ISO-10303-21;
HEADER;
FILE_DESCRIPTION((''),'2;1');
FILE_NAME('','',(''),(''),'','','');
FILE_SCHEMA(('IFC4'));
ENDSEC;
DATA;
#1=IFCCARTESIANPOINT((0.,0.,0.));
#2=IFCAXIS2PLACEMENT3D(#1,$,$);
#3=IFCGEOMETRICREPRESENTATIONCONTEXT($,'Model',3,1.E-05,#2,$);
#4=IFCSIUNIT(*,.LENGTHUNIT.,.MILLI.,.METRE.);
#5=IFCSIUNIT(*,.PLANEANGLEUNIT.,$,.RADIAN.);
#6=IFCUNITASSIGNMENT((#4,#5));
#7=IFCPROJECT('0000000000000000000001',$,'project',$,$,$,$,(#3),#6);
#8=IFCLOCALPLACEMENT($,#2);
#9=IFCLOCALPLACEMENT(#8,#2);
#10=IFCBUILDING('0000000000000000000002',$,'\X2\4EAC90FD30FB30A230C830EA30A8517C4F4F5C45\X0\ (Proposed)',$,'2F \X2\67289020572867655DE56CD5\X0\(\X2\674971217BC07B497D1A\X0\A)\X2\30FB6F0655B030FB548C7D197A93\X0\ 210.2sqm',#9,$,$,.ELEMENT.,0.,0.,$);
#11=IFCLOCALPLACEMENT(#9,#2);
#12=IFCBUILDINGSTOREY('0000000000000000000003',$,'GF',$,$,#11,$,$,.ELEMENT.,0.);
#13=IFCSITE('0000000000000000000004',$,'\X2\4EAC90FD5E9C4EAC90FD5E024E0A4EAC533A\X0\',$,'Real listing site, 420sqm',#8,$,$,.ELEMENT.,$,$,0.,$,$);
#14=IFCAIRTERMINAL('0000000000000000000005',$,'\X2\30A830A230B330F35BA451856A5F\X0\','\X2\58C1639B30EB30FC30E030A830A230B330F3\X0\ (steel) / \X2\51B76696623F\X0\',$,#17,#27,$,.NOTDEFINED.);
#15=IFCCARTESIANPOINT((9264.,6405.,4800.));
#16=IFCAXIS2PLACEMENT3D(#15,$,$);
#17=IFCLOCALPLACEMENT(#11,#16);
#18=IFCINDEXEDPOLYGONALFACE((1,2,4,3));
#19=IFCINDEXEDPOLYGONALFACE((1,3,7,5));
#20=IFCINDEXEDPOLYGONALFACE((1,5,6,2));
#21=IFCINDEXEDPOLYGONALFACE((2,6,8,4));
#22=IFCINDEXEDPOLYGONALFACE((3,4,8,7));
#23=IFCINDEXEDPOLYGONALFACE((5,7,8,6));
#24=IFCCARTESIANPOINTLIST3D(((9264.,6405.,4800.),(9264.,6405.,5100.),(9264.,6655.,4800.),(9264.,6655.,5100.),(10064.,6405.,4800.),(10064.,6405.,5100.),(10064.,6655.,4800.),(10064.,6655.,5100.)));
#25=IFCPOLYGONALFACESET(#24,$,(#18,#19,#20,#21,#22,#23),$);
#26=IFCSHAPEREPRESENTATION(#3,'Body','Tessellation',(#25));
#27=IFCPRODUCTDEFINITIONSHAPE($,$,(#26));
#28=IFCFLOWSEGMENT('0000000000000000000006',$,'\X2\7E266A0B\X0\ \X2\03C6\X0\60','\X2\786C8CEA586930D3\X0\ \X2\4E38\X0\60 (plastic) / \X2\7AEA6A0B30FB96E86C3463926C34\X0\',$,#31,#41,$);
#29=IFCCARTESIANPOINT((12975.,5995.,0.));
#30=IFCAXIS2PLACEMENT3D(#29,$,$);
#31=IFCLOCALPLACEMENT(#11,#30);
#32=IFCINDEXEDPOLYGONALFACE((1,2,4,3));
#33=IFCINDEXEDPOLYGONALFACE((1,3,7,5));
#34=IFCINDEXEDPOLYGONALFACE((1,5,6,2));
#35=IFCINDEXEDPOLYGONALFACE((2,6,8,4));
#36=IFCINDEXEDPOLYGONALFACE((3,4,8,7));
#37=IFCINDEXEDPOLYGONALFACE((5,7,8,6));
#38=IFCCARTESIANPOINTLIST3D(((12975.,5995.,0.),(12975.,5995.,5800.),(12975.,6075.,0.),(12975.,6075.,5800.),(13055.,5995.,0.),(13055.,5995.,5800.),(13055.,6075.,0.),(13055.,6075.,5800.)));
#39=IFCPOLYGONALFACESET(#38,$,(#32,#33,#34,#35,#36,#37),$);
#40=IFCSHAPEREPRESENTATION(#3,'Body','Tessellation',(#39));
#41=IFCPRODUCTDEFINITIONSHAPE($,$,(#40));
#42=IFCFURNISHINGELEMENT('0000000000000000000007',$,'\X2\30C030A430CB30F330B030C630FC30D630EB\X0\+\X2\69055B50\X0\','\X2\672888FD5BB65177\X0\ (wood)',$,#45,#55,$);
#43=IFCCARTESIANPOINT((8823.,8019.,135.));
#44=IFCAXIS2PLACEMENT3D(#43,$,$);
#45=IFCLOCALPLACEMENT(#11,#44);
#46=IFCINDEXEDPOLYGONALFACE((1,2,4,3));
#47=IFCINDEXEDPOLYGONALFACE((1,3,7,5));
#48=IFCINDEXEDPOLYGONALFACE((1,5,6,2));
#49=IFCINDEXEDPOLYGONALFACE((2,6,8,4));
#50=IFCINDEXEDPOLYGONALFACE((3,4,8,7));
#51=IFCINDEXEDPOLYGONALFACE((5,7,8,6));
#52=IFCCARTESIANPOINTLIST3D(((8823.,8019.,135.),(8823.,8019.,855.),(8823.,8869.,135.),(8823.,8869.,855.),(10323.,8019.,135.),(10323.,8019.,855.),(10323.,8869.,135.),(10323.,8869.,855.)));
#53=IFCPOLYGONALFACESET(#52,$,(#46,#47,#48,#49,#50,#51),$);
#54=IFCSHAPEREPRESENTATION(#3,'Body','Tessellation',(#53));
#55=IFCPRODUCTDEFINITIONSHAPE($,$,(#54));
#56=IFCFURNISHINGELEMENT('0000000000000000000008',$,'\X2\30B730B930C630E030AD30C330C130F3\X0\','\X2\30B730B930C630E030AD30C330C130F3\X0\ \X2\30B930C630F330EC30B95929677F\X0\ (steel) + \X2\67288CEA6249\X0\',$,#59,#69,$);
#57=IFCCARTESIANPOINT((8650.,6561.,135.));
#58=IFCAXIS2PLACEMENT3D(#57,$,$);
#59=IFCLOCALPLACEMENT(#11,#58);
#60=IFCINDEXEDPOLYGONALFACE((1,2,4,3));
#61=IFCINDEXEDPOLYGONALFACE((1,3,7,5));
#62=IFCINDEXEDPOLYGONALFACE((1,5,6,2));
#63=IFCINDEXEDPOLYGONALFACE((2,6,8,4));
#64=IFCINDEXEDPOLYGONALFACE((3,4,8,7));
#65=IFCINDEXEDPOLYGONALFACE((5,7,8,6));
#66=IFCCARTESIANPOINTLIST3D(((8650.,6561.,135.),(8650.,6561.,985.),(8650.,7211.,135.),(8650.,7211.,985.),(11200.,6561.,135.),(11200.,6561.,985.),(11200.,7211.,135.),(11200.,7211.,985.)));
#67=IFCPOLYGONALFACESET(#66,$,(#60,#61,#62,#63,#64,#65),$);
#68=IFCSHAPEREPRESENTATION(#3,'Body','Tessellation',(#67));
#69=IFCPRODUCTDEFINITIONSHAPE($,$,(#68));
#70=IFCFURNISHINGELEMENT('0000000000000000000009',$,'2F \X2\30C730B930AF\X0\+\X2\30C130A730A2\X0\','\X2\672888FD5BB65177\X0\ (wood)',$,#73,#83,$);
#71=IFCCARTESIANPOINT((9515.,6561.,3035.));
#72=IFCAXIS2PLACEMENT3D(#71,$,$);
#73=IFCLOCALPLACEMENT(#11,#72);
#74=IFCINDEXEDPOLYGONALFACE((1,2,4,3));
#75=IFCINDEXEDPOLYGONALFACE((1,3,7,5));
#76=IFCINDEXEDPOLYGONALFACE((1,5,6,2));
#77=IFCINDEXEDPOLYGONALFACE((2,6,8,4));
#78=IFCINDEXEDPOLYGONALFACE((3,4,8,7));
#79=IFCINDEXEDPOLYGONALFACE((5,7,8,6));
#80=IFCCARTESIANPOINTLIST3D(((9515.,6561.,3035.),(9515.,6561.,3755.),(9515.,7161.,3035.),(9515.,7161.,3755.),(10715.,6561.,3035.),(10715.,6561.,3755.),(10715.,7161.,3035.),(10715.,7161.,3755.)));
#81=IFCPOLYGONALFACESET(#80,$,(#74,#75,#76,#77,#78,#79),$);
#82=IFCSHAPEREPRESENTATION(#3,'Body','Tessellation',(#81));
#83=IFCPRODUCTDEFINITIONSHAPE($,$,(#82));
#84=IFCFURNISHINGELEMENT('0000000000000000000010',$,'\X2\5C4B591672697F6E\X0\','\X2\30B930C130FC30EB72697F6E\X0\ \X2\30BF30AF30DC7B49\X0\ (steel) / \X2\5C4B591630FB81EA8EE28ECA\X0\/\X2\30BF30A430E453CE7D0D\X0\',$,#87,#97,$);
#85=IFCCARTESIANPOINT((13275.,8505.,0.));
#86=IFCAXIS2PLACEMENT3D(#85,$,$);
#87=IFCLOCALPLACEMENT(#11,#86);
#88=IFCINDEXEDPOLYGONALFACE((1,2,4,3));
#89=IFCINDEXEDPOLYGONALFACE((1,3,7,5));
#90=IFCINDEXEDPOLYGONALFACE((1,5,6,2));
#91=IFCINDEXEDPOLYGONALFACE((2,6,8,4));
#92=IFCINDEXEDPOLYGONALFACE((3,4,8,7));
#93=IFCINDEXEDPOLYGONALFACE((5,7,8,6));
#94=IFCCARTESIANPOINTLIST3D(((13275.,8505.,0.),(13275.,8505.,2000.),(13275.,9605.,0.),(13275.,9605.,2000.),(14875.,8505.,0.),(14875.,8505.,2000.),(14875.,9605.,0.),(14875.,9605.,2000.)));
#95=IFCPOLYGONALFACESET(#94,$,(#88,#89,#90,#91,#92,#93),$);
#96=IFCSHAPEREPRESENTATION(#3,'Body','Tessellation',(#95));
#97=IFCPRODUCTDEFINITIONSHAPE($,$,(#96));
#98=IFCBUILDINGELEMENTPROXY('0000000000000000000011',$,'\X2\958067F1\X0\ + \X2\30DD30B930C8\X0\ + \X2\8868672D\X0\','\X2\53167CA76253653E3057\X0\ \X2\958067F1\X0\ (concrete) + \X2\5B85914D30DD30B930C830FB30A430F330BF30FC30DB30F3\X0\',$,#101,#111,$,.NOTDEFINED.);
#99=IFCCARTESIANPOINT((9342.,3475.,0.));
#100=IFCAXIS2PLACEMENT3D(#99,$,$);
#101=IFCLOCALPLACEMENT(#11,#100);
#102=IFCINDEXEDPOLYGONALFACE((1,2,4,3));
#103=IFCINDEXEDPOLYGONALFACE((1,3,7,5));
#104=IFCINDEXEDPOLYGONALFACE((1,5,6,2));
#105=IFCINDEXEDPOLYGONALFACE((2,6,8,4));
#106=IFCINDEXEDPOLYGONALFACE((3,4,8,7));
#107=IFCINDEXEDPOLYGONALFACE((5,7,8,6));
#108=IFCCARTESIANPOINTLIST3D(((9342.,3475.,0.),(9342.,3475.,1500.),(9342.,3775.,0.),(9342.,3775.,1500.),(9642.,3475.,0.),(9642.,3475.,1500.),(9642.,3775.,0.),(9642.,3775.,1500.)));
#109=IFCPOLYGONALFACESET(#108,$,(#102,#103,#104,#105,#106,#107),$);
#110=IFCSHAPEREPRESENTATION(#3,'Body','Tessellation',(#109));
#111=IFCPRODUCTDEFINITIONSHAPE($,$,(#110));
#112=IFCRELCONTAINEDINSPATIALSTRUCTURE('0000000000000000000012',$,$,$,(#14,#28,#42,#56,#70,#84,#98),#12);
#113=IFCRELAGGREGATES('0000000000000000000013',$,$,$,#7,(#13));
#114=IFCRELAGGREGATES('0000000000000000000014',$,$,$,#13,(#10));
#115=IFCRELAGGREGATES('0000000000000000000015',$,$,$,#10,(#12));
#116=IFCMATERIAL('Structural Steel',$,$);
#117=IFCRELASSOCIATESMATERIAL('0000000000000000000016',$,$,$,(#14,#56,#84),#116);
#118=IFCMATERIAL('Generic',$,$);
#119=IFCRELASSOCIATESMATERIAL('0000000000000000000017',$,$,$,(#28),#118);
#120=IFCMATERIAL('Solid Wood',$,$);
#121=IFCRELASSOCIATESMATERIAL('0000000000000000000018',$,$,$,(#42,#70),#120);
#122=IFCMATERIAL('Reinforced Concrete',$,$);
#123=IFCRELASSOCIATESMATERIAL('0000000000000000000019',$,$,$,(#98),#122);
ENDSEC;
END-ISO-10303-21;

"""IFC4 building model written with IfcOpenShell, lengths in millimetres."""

from ifc_helpers import new_model, si_unit, frame, frame_2d, origin, place, context, project, spatial, rectangle, extrude, material, element, save


model = new_model("IFC4")

# Units and contexts
model_context = context("Model", 3, precision=1e-05, world=origin())
ifc_project = project(units=[si_unit("LENGTHUNIT", "METRE", prefix="MILLI"), si_unit("PLANEANGLEUNIT", "RADIAN")], contexts=[model_context])

# Site, building, storey
site_placement = place(None, origin())
site = spatial("IfcSite", under=ifc_project, at=site_placement, Name="京都府京都市上京区", ObjectType="Real listing site, 420sqm", CompositionType="ELEMENT", RefElevation=0.0)
building_placement = place(site_placement, origin())
building = spatial("IfcBuilding", under=site, at=building_placement, Name="京都・アトリエ兼住居 (Proposed)", ObjectType="2F 木造在来工法(杉無節等級A)・漆喰・和紙窓 210.2sqm", CompositionType="ELEMENT", ElevationOfRefHeight=0.0, ElevationOfTerrain=0.0)
storey_placement = place(building_placement, origin())
storey = spatial("IfcBuildingStorey", under=building, at=storey_placement, Name="GF", CompositionType="ELEMENT", Elevation=0.0)

# Shared definitions
ifc_material_1 = material(Name="Solid Wood")

# Shared definitions
ifc_material_2 = material(Name="Reinforced Concrete")

# Shared definitions
ifc_material_3 = material(Name="Structural Steel")

# Shared definitions
ifc_material_4 = material(Name="Generic")

# Air terminal
air_terminal_placement = place(storey_placement, frame((9264.0, 6405.0, 4800.0)))
element("IfcAirTerminal", 1, at=air_terminal_placement, inside=storey, material=ifc_material_3, Name="エアコン室内機", Description="壁掛ルームエアコン (steel) / 冷暖房", PredefinedType="NOTDEFINED", context=model_context, shape_type="SweptSolid", body=[
    extrude(rectangle(XDim=800.0, YDim=250.0, at=frame_2d((400.0, 125.0))), frame((9264.0, 6405.0, 4800.0)), (0.0, 0.0, 1.0), 300.0),
])

# Flow segment
flow_segment_placement = place(storey_placement, frame((12975.0, 5995.0, 0.0)))
element("IfcFlowSegment", 2, at=flow_segment_placement, inside=storey, material=ifc_material_4, Name="縦樋 φ60", Description="硬質塩ビ 丸60 (plastic) / 竪樋・雨水排水", context=model_context, shape_type="SweptSolid", body=[
    extrude(rectangle(XDim=80.0, YDim=80.0, at=frame_2d((40.0, 40.0))), frame((12975.0, 5995.0, 0.0)), (0.0, 0.0, 1.0), 5800.0),
])

# Furnishing elements
furnishing_1_placement = place(storey_placement, frame((8823.0, 8019.0, 135.0)))
element("IfcFurnishingElement", 3, at=furnishing_1_placement, inside=storey, material=ifc_material_1, Name="ダイニングテーブル+椅子", Description="木製家具 (wood)", context=model_context, shape_type="SweptSolid", body=[
    extrude(rectangle(XDim=1500.0, YDim=850.0, at=frame_2d((750.0, 425.0))), frame((8823.0, 8019.0, 135.0)), (0.0, 0.0, 1.0), 720.0),
])
furnishing_2_placement = place(storey_placement, frame((8650.0, 6561.0, 135.0)))
element("IfcFurnishingElement", 4, at=furnishing_2_placement, inside=storey, material=ifc_material_3, Name="システムキッチン", Description="システムキッチン ステンレス天板 (steel) + 木質扉", context=model_context, shape_type="SweptSolid", body=[
    extrude(rectangle(XDim=2550.0, YDim=650.0, at=frame_2d((1275.0, 325.0))), frame((8650.0, 6561.0, 135.0)), (0.0, 0.0, 1.0), 850.0),
])
furnishing_3_placement = place(storey_placement, frame((9515.0, 6561.0, 3035.0)))
element("IfcFurnishingElement", 5, at=furnishing_3_placement, inside=storey, material=ifc_material_1, Name="2F デスク+チェア", Description="木製家具 (wood)", context=model_context, shape_type="SweptSolid", body=[
    extrude(rectangle(XDim=1200.0, YDim=600.0, at=frame_2d((600.0, 300.0))), frame((9515.0, 6561.0, 3035.0)), (0.0, 0.0, 1.0), 720.0),
])
furnishing_4_placement = place(storey_placement, frame((13275.0, 8505.0, 0.0)))
element("IfcFurnishingElement", 6, at=furnishing_4_placement, inside=storey, material=ifc_material_3, Name="屋外物置", Description="スチール物置 タクボ等 (steel) / 屋外・自転車/タイヤ収納", context=model_context, shape_type="SweptSolid", body=[
    extrude(rectangle(XDim=1600.0, YDim=1100.0, at=frame_2d((800.0, 550.0))), frame((13275.0, 8505.0, 0.0)), (0.0, 0.0, 1.0), 2000.0),
])

# Building element proxy
proxy_placement = place(storey_placement, frame((9342.0, 3475.0, 0.0)))
element("IfcBuildingElementProxy", 7, at=proxy_placement, inside=storey, material=ifc_material_2, Name="門柱 + ポスト + 表札", Description="化粧打放し 門柱 (concrete) + 宅配ポスト・インターホン", PredefinedType="NOTDEFINED", context=model_context, shape_type="SweptSolid", body=[
    extrude(rectangle(XDim=300.0, YDim=300.0, at=frame_2d((150.0, 150.0))), frame((9342.0, 3475.0, 0.0)), (0.0, 0.0, 1.0), 1500.0),
])

save(model, "model.ifc")
